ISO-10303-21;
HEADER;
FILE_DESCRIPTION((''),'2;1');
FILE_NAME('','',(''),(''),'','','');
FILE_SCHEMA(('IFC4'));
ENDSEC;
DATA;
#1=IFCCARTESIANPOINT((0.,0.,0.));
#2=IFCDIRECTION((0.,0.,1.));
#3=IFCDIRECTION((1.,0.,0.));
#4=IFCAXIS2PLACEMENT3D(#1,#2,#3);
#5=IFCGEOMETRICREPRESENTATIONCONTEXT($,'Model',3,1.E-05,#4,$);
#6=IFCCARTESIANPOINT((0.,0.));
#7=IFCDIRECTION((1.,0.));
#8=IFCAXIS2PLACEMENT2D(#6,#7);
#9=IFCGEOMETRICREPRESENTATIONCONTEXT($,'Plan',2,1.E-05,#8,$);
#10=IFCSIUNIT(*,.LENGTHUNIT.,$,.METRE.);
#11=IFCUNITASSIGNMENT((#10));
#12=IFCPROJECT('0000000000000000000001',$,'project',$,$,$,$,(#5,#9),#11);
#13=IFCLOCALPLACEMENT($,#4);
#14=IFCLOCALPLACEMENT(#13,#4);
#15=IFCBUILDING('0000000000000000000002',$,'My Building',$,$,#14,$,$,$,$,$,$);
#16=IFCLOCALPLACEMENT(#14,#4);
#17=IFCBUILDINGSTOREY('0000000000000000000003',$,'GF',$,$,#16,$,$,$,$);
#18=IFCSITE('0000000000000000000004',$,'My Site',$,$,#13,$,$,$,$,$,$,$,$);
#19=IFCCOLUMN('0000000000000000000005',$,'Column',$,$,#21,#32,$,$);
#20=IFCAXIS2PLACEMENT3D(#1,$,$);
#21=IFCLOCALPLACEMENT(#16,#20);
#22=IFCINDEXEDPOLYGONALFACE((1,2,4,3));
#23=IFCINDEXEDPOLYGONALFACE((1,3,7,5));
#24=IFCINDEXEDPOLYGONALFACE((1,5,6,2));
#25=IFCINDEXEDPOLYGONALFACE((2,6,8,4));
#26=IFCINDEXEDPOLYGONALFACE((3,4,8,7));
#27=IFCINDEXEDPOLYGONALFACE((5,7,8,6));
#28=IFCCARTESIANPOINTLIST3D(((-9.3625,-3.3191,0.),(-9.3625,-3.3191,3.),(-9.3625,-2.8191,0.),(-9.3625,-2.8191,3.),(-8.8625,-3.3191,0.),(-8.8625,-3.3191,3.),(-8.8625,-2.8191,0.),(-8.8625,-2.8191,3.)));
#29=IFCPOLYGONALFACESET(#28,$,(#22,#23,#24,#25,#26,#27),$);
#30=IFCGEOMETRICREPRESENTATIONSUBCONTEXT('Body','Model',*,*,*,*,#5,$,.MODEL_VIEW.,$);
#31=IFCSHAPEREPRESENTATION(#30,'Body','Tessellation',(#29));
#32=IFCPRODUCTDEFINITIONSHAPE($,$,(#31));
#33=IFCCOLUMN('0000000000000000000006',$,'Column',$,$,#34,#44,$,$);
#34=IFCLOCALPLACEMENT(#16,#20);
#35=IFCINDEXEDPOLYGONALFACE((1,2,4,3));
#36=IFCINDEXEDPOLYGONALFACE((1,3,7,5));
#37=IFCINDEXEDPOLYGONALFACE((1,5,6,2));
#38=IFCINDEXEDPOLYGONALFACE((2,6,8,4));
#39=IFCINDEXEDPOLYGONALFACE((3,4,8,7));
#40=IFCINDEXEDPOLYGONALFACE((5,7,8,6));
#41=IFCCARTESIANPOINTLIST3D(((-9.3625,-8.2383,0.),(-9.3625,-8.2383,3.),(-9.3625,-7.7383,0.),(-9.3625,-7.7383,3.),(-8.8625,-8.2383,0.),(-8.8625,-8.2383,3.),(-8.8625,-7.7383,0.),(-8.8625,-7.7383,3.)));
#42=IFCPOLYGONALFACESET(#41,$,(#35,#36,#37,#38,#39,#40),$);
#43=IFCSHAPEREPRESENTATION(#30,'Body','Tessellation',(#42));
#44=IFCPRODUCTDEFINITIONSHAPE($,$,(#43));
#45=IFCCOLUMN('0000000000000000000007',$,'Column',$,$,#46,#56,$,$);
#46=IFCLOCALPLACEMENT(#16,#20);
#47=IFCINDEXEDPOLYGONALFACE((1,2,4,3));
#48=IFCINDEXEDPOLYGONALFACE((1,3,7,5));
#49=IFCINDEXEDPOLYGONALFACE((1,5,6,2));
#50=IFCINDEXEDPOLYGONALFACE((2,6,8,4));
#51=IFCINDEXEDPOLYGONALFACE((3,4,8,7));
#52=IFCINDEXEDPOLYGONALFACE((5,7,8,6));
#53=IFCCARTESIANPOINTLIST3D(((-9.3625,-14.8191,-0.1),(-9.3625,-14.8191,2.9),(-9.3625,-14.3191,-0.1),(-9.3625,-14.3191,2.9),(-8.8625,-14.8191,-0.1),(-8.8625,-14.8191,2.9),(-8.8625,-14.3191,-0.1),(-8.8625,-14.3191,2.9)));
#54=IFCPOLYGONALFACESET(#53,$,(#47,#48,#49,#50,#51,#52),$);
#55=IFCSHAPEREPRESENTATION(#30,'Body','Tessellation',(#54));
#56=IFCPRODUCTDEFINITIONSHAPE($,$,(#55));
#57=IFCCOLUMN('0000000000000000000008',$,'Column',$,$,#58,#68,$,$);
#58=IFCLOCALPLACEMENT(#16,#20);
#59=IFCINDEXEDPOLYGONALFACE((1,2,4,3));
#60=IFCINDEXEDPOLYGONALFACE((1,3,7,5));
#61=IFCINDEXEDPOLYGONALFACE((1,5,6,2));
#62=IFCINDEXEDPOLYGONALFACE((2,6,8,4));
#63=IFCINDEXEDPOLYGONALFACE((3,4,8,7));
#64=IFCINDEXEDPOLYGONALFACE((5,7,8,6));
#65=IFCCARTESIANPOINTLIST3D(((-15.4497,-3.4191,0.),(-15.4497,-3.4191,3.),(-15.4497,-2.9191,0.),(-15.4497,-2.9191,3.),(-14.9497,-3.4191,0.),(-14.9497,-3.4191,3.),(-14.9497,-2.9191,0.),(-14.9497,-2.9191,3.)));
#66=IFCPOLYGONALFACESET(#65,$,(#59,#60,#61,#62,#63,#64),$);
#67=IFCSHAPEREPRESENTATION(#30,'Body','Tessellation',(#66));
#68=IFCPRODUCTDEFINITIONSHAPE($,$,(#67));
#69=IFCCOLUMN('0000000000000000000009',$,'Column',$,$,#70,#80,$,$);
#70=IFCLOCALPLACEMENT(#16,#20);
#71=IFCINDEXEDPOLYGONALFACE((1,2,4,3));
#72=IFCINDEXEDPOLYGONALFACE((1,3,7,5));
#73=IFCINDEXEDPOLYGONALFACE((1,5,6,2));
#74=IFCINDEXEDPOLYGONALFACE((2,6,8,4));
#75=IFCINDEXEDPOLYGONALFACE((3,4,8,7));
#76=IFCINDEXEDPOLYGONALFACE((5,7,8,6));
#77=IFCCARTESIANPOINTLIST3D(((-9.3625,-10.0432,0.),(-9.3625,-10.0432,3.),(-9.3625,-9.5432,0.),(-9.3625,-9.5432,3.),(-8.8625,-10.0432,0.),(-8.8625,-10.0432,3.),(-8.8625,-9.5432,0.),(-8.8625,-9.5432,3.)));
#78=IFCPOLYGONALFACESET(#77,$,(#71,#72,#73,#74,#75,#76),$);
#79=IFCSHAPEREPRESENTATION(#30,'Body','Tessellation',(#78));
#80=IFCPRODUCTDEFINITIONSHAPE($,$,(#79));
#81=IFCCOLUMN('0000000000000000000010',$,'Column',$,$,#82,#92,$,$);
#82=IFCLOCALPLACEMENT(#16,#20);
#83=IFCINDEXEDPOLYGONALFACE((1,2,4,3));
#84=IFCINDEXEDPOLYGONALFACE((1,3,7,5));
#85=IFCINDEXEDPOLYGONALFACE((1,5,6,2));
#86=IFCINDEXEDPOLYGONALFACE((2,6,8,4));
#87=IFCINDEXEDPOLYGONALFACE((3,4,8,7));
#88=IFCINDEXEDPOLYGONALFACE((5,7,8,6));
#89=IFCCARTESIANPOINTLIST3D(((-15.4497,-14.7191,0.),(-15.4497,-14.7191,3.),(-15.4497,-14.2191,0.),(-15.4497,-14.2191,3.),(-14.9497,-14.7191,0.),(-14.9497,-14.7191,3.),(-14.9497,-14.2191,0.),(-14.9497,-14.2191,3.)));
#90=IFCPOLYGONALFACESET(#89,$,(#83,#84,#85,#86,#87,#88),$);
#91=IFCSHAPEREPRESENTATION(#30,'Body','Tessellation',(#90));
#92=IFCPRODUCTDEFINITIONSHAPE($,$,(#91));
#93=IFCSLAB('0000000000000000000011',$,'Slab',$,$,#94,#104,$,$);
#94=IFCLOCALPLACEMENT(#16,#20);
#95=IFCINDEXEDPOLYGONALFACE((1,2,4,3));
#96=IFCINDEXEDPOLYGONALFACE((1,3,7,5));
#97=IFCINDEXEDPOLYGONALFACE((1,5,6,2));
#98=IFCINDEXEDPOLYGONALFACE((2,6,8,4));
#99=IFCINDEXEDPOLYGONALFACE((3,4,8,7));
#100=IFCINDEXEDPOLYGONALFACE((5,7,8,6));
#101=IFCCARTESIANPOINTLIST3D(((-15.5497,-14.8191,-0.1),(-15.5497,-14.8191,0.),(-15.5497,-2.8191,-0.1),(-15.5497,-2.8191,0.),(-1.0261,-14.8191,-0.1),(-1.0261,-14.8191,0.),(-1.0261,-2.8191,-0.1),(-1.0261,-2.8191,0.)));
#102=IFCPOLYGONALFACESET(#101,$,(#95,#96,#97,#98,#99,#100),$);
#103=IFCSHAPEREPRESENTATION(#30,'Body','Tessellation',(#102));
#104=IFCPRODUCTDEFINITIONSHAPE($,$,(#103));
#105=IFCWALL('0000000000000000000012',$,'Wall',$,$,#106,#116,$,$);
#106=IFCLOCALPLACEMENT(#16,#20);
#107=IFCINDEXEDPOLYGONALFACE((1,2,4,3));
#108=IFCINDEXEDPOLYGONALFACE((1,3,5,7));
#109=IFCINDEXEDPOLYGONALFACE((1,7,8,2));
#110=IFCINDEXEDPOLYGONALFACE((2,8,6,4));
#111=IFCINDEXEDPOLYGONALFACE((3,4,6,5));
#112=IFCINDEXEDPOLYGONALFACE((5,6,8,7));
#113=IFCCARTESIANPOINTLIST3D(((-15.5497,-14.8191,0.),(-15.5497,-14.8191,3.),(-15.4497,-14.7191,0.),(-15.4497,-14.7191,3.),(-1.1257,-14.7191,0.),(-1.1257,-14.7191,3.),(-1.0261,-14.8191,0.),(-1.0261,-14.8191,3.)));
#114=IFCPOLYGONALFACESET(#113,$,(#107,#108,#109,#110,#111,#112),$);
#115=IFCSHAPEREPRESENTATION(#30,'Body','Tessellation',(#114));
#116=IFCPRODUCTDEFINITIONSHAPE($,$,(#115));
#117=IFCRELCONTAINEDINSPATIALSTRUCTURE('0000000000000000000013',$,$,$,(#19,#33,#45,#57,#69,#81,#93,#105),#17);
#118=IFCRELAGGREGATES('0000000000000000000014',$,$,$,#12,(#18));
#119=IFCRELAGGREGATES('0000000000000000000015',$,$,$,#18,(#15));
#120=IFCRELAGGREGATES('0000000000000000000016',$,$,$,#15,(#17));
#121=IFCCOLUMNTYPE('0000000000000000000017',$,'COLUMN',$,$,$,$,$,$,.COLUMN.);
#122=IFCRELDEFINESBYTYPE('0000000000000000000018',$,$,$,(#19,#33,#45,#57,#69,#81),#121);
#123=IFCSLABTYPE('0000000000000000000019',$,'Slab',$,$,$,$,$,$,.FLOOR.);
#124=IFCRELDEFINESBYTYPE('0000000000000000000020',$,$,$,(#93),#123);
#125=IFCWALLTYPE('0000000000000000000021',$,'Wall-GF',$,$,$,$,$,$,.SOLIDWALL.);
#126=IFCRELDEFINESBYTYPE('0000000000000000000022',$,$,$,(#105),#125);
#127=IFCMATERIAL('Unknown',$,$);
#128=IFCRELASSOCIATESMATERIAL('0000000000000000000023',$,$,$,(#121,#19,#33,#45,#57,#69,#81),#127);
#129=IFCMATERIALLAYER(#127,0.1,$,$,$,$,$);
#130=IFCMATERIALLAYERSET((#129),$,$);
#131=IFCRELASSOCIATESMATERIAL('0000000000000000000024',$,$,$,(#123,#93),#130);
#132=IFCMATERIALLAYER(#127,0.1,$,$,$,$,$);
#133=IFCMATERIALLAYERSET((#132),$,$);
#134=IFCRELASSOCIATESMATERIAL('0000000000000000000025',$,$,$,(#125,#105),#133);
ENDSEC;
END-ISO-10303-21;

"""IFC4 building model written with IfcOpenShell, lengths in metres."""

from ifc_helpers import new_model, si_unit, frame, origin_with_axes, origin_2d_with_axis, place, context, subcontext, project, spatial, line, indexed_curve, rectangle, outline, extrude, material, layer, layer_set, layer_usage, material_profile, profile_set, profile_usage, type_object, element, save


model = new_model("IFC4")

# Units and contexts
model_context = context("Model", 3, precision=1e-05, world=origin_with_axes())
plan_context = context("Plan", 2, precision=1e-05, world=origin_2d_with_axis())
body_context_1 = subcontext(model_context, "Body", "Model", "MODEL_VIEW")
ifc_project = project(units=[si_unit("LENGTHUNIT", "METRE")], contexts=[model_context, plan_context])

# Site, building, storey
site_placement = place(None, origin_with_axes())
site = spatial("IfcSite", under=ifc_project, at=site_placement, Name="My Site")
building_placement = place(site_placement, origin_with_axes())
building = spatial("IfcBuilding", under=site, at=building_placement, Name="My Building")
storey_placement = place(building_placement, origin_with_axes())
storey = spatial("IfcBuildingStorey", under=building, at=storey_placement, Name="GF")

# Columns
ifc_material = material(Name="Unknown")
ifc_material_profile_1 = material_profile(ifc_material, rectangle(XDim=0.5, YDim=0.5))
ifc_profile_set_1 = profile_set([ifc_material_profile_1])
ifc_profile_usage_1 = profile_usage(ifc_profile_set_1, cardinal=5)
column_type = type_object("IfcColumnType", Name="COLUMN", PredefinedType="COLUMN", material=ifc_profile_set_1)
column_1_placement = place(storey_placement, frame((-9.1125, -3.0691, 0.0), z_axis=(0.0, 0.0, 1.0), x_axis=(1.0, 0.0, 0.0)))
element("IfcColumn", 1, at=column_1_placement, inside=storey, type_object=column_type, material=ifc_profile_usage_1, Name="Column", context=body_context_1, shape_type="SweptSolid", body=[
    extrude(rectangle(XDim=0.5, YDim=0.5), origin_with_axes(), (0.0, 0.0, 1.0), 3.0),
])
ifc_profile_usage_2 = profile_usage(ifc_profile_set_1, cardinal=5)
column_2_placement = place(storey_placement, frame((-9.1125, -7.9883, 0.0), z_axis=(0.0, 0.0, 1.0), x_axis=(1.0, 0.0, 0.0)))
element("IfcColumn", 2, at=column_2_placement, inside=storey, type_object=column_type, material=ifc_profile_usage_2, Name="Column", context=body_context_1, shape_type="SweptSolid", body=[
    extrude(rectangle(XDim=0.5, YDim=0.5), origin_with_axes(), (0.0, 0.0, 1.0), 3.0),
])
ifc_profile_usage_3 = profile_usage(ifc_profile_set_1, cardinal=5)
column_3_placement = place(storey_placement, frame((-9.1125, -14.5691, -0.1), z_axis=(0.0, 0.0, 1.0), x_axis=(1.0, 0.0, 0.0)))
element("IfcColumn", 3, at=column_3_placement, inside=storey, type_object=column_type, material=ifc_profile_usage_3, Name="Column", context=body_context_1, shape_type="SweptSolid", body=[
    extrude(rectangle(XDim=0.5, YDim=0.5), origin_with_axes(), (0.0, 0.0, 1.0), 3.0),
])
ifc_profile_usage_4 = profile_usage(ifc_profile_set_1, cardinal=5)
column_4_placement = place(storey_placement, frame((-15.1997, -3.1691, 0.0), z_axis=(0.0, 0.0, 1.0), x_axis=(1.0, 0.0, 0.0)))
element("IfcColumn", 4, at=column_4_placement, inside=storey, type_object=column_type, material=ifc_profile_usage_4, Name="Column", context=body_context_1, shape_type="SweptSolid", body=[
    extrude(rectangle(XDim=0.5, YDim=0.5), origin_with_axes(), (0.0, 0.0, 1.0), 3.0),
])
ifc_profile_usage_5 = profile_usage(ifc_profile_set_1, cardinal=5)
column_5_placement = place(storey_placement, frame((-9.1125, -9.7932, 0.0), z_axis=(0.0, 0.0, 1.0), x_axis=(1.0, 0.0, 0.0)))
element("IfcColumn", 5, at=column_5_placement, inside=storey, type_object=column_type, material=ifc_profile_usage_5, Name="Column", context=body_context_1, shape_type="SweptSolid", body=[
    extrude(rectangle(XDim=0.5, YDim=0.5), origin_with_axes(), (0.0, 0.0, 1.0), 3.0),
])
ifc_profile_usage_6 = profile_usage(ifc_profile_set_1, cardinal=5)
column_6_placement = place(storey_placement, frame((-15.1997, -14.4691, 0.0), z_axis=(0.0, 0.0, 1.0), x_axis=(1.0, 0.0, 0.0)))
element("IfcColumn", 6, at=column_6_placement, inside=storey, type_object=column_type, material=ifc_profile_usage_6, Name="Column", context=body_context_1, shape_type="SweptSolid", body=[
    extrude(rectangle(XDim=0.5, YDim=0.5), origin_with_axes(), (0.0, 0.0, 1.0), 3.0),
])

# Slab
ifc_layer_1 = layer(ifc_material, 0.1)
ifc_layer_set_1 = layer_set([ifc_layer_1])
ifc_layer_usage_1 = layer_usage(ifc_layer_set_1, "AXIS3", "POSITIVE", -0.1)
slab_type = type_object("IfcSlabType", Name="Slab", PredefinedType="FLOOR", material=ifc_layer_set_1)
slab_placement = place(storey_placement, frame((-15.5497, -2.8191, 0.0), z_axis=(0.0, 0.0, 1.0), x_axis=(1.0, 0.0, 0.0)))
element("IfcSlab", 7, at=slab_placement, inside=storey, type_object=slab_type, material=ifc_layer_usage_1, Name="Slab", context=body_context_1, shape_type="SweptSolid", body=[
    extrude(outline(indexed_curve([(0.0, -12.0), (14.5236, -12.0), (14.5236, 0.0), (0.0, 0.0), (0.0, -12.0)])), frame((0.0, 0.0, -0.1), z_axis=(0.0, 0.0, 1.0), x_axis=(1.0, 0.0, 0.0)), (0.0, 0.0, 1.0), 0.1),
])

# Wall
ifc_layer_2 = layer(ifc_material, 0.1)
ifc_layer_set_2 = layer_set([ifc_layer_2])
ifc_layer_usage_2 = layer_usage(ifc_layer_set_2, "AXIS2", "POSITIVE", 0.0)
wall_type = type_object("IfcWallType", Name="Wall-GF", PredefinedType="SOLIDWALL", material=ifc_layer_set_2)
wall_1_placement = place(storey_placement, frame((-15.5497, -14.8191, 0.0), z_axis=(0.0, 0.0, 1.0), x_axis=(1.0, 0.0, 0.0)))
element("IfcWall", 8, at=wall_1_placement, inside=storey, type_object=wall_type, material=ifc_layer_usage_2, Name="Wall", context=body_context_1, shape_type="SweptSolid", body=[
    extrude(outline(indexed_curve([(0.0, 0.0), (0.1, 0.1), (14.424, 0.1), (14.5236, 0.0)], segments=[line(1, 2, 3, 4, 1)])), origin_with_axes(), (0.0, 0.0, 1.0), 3.0),
])

save(model, "model.ifc")
